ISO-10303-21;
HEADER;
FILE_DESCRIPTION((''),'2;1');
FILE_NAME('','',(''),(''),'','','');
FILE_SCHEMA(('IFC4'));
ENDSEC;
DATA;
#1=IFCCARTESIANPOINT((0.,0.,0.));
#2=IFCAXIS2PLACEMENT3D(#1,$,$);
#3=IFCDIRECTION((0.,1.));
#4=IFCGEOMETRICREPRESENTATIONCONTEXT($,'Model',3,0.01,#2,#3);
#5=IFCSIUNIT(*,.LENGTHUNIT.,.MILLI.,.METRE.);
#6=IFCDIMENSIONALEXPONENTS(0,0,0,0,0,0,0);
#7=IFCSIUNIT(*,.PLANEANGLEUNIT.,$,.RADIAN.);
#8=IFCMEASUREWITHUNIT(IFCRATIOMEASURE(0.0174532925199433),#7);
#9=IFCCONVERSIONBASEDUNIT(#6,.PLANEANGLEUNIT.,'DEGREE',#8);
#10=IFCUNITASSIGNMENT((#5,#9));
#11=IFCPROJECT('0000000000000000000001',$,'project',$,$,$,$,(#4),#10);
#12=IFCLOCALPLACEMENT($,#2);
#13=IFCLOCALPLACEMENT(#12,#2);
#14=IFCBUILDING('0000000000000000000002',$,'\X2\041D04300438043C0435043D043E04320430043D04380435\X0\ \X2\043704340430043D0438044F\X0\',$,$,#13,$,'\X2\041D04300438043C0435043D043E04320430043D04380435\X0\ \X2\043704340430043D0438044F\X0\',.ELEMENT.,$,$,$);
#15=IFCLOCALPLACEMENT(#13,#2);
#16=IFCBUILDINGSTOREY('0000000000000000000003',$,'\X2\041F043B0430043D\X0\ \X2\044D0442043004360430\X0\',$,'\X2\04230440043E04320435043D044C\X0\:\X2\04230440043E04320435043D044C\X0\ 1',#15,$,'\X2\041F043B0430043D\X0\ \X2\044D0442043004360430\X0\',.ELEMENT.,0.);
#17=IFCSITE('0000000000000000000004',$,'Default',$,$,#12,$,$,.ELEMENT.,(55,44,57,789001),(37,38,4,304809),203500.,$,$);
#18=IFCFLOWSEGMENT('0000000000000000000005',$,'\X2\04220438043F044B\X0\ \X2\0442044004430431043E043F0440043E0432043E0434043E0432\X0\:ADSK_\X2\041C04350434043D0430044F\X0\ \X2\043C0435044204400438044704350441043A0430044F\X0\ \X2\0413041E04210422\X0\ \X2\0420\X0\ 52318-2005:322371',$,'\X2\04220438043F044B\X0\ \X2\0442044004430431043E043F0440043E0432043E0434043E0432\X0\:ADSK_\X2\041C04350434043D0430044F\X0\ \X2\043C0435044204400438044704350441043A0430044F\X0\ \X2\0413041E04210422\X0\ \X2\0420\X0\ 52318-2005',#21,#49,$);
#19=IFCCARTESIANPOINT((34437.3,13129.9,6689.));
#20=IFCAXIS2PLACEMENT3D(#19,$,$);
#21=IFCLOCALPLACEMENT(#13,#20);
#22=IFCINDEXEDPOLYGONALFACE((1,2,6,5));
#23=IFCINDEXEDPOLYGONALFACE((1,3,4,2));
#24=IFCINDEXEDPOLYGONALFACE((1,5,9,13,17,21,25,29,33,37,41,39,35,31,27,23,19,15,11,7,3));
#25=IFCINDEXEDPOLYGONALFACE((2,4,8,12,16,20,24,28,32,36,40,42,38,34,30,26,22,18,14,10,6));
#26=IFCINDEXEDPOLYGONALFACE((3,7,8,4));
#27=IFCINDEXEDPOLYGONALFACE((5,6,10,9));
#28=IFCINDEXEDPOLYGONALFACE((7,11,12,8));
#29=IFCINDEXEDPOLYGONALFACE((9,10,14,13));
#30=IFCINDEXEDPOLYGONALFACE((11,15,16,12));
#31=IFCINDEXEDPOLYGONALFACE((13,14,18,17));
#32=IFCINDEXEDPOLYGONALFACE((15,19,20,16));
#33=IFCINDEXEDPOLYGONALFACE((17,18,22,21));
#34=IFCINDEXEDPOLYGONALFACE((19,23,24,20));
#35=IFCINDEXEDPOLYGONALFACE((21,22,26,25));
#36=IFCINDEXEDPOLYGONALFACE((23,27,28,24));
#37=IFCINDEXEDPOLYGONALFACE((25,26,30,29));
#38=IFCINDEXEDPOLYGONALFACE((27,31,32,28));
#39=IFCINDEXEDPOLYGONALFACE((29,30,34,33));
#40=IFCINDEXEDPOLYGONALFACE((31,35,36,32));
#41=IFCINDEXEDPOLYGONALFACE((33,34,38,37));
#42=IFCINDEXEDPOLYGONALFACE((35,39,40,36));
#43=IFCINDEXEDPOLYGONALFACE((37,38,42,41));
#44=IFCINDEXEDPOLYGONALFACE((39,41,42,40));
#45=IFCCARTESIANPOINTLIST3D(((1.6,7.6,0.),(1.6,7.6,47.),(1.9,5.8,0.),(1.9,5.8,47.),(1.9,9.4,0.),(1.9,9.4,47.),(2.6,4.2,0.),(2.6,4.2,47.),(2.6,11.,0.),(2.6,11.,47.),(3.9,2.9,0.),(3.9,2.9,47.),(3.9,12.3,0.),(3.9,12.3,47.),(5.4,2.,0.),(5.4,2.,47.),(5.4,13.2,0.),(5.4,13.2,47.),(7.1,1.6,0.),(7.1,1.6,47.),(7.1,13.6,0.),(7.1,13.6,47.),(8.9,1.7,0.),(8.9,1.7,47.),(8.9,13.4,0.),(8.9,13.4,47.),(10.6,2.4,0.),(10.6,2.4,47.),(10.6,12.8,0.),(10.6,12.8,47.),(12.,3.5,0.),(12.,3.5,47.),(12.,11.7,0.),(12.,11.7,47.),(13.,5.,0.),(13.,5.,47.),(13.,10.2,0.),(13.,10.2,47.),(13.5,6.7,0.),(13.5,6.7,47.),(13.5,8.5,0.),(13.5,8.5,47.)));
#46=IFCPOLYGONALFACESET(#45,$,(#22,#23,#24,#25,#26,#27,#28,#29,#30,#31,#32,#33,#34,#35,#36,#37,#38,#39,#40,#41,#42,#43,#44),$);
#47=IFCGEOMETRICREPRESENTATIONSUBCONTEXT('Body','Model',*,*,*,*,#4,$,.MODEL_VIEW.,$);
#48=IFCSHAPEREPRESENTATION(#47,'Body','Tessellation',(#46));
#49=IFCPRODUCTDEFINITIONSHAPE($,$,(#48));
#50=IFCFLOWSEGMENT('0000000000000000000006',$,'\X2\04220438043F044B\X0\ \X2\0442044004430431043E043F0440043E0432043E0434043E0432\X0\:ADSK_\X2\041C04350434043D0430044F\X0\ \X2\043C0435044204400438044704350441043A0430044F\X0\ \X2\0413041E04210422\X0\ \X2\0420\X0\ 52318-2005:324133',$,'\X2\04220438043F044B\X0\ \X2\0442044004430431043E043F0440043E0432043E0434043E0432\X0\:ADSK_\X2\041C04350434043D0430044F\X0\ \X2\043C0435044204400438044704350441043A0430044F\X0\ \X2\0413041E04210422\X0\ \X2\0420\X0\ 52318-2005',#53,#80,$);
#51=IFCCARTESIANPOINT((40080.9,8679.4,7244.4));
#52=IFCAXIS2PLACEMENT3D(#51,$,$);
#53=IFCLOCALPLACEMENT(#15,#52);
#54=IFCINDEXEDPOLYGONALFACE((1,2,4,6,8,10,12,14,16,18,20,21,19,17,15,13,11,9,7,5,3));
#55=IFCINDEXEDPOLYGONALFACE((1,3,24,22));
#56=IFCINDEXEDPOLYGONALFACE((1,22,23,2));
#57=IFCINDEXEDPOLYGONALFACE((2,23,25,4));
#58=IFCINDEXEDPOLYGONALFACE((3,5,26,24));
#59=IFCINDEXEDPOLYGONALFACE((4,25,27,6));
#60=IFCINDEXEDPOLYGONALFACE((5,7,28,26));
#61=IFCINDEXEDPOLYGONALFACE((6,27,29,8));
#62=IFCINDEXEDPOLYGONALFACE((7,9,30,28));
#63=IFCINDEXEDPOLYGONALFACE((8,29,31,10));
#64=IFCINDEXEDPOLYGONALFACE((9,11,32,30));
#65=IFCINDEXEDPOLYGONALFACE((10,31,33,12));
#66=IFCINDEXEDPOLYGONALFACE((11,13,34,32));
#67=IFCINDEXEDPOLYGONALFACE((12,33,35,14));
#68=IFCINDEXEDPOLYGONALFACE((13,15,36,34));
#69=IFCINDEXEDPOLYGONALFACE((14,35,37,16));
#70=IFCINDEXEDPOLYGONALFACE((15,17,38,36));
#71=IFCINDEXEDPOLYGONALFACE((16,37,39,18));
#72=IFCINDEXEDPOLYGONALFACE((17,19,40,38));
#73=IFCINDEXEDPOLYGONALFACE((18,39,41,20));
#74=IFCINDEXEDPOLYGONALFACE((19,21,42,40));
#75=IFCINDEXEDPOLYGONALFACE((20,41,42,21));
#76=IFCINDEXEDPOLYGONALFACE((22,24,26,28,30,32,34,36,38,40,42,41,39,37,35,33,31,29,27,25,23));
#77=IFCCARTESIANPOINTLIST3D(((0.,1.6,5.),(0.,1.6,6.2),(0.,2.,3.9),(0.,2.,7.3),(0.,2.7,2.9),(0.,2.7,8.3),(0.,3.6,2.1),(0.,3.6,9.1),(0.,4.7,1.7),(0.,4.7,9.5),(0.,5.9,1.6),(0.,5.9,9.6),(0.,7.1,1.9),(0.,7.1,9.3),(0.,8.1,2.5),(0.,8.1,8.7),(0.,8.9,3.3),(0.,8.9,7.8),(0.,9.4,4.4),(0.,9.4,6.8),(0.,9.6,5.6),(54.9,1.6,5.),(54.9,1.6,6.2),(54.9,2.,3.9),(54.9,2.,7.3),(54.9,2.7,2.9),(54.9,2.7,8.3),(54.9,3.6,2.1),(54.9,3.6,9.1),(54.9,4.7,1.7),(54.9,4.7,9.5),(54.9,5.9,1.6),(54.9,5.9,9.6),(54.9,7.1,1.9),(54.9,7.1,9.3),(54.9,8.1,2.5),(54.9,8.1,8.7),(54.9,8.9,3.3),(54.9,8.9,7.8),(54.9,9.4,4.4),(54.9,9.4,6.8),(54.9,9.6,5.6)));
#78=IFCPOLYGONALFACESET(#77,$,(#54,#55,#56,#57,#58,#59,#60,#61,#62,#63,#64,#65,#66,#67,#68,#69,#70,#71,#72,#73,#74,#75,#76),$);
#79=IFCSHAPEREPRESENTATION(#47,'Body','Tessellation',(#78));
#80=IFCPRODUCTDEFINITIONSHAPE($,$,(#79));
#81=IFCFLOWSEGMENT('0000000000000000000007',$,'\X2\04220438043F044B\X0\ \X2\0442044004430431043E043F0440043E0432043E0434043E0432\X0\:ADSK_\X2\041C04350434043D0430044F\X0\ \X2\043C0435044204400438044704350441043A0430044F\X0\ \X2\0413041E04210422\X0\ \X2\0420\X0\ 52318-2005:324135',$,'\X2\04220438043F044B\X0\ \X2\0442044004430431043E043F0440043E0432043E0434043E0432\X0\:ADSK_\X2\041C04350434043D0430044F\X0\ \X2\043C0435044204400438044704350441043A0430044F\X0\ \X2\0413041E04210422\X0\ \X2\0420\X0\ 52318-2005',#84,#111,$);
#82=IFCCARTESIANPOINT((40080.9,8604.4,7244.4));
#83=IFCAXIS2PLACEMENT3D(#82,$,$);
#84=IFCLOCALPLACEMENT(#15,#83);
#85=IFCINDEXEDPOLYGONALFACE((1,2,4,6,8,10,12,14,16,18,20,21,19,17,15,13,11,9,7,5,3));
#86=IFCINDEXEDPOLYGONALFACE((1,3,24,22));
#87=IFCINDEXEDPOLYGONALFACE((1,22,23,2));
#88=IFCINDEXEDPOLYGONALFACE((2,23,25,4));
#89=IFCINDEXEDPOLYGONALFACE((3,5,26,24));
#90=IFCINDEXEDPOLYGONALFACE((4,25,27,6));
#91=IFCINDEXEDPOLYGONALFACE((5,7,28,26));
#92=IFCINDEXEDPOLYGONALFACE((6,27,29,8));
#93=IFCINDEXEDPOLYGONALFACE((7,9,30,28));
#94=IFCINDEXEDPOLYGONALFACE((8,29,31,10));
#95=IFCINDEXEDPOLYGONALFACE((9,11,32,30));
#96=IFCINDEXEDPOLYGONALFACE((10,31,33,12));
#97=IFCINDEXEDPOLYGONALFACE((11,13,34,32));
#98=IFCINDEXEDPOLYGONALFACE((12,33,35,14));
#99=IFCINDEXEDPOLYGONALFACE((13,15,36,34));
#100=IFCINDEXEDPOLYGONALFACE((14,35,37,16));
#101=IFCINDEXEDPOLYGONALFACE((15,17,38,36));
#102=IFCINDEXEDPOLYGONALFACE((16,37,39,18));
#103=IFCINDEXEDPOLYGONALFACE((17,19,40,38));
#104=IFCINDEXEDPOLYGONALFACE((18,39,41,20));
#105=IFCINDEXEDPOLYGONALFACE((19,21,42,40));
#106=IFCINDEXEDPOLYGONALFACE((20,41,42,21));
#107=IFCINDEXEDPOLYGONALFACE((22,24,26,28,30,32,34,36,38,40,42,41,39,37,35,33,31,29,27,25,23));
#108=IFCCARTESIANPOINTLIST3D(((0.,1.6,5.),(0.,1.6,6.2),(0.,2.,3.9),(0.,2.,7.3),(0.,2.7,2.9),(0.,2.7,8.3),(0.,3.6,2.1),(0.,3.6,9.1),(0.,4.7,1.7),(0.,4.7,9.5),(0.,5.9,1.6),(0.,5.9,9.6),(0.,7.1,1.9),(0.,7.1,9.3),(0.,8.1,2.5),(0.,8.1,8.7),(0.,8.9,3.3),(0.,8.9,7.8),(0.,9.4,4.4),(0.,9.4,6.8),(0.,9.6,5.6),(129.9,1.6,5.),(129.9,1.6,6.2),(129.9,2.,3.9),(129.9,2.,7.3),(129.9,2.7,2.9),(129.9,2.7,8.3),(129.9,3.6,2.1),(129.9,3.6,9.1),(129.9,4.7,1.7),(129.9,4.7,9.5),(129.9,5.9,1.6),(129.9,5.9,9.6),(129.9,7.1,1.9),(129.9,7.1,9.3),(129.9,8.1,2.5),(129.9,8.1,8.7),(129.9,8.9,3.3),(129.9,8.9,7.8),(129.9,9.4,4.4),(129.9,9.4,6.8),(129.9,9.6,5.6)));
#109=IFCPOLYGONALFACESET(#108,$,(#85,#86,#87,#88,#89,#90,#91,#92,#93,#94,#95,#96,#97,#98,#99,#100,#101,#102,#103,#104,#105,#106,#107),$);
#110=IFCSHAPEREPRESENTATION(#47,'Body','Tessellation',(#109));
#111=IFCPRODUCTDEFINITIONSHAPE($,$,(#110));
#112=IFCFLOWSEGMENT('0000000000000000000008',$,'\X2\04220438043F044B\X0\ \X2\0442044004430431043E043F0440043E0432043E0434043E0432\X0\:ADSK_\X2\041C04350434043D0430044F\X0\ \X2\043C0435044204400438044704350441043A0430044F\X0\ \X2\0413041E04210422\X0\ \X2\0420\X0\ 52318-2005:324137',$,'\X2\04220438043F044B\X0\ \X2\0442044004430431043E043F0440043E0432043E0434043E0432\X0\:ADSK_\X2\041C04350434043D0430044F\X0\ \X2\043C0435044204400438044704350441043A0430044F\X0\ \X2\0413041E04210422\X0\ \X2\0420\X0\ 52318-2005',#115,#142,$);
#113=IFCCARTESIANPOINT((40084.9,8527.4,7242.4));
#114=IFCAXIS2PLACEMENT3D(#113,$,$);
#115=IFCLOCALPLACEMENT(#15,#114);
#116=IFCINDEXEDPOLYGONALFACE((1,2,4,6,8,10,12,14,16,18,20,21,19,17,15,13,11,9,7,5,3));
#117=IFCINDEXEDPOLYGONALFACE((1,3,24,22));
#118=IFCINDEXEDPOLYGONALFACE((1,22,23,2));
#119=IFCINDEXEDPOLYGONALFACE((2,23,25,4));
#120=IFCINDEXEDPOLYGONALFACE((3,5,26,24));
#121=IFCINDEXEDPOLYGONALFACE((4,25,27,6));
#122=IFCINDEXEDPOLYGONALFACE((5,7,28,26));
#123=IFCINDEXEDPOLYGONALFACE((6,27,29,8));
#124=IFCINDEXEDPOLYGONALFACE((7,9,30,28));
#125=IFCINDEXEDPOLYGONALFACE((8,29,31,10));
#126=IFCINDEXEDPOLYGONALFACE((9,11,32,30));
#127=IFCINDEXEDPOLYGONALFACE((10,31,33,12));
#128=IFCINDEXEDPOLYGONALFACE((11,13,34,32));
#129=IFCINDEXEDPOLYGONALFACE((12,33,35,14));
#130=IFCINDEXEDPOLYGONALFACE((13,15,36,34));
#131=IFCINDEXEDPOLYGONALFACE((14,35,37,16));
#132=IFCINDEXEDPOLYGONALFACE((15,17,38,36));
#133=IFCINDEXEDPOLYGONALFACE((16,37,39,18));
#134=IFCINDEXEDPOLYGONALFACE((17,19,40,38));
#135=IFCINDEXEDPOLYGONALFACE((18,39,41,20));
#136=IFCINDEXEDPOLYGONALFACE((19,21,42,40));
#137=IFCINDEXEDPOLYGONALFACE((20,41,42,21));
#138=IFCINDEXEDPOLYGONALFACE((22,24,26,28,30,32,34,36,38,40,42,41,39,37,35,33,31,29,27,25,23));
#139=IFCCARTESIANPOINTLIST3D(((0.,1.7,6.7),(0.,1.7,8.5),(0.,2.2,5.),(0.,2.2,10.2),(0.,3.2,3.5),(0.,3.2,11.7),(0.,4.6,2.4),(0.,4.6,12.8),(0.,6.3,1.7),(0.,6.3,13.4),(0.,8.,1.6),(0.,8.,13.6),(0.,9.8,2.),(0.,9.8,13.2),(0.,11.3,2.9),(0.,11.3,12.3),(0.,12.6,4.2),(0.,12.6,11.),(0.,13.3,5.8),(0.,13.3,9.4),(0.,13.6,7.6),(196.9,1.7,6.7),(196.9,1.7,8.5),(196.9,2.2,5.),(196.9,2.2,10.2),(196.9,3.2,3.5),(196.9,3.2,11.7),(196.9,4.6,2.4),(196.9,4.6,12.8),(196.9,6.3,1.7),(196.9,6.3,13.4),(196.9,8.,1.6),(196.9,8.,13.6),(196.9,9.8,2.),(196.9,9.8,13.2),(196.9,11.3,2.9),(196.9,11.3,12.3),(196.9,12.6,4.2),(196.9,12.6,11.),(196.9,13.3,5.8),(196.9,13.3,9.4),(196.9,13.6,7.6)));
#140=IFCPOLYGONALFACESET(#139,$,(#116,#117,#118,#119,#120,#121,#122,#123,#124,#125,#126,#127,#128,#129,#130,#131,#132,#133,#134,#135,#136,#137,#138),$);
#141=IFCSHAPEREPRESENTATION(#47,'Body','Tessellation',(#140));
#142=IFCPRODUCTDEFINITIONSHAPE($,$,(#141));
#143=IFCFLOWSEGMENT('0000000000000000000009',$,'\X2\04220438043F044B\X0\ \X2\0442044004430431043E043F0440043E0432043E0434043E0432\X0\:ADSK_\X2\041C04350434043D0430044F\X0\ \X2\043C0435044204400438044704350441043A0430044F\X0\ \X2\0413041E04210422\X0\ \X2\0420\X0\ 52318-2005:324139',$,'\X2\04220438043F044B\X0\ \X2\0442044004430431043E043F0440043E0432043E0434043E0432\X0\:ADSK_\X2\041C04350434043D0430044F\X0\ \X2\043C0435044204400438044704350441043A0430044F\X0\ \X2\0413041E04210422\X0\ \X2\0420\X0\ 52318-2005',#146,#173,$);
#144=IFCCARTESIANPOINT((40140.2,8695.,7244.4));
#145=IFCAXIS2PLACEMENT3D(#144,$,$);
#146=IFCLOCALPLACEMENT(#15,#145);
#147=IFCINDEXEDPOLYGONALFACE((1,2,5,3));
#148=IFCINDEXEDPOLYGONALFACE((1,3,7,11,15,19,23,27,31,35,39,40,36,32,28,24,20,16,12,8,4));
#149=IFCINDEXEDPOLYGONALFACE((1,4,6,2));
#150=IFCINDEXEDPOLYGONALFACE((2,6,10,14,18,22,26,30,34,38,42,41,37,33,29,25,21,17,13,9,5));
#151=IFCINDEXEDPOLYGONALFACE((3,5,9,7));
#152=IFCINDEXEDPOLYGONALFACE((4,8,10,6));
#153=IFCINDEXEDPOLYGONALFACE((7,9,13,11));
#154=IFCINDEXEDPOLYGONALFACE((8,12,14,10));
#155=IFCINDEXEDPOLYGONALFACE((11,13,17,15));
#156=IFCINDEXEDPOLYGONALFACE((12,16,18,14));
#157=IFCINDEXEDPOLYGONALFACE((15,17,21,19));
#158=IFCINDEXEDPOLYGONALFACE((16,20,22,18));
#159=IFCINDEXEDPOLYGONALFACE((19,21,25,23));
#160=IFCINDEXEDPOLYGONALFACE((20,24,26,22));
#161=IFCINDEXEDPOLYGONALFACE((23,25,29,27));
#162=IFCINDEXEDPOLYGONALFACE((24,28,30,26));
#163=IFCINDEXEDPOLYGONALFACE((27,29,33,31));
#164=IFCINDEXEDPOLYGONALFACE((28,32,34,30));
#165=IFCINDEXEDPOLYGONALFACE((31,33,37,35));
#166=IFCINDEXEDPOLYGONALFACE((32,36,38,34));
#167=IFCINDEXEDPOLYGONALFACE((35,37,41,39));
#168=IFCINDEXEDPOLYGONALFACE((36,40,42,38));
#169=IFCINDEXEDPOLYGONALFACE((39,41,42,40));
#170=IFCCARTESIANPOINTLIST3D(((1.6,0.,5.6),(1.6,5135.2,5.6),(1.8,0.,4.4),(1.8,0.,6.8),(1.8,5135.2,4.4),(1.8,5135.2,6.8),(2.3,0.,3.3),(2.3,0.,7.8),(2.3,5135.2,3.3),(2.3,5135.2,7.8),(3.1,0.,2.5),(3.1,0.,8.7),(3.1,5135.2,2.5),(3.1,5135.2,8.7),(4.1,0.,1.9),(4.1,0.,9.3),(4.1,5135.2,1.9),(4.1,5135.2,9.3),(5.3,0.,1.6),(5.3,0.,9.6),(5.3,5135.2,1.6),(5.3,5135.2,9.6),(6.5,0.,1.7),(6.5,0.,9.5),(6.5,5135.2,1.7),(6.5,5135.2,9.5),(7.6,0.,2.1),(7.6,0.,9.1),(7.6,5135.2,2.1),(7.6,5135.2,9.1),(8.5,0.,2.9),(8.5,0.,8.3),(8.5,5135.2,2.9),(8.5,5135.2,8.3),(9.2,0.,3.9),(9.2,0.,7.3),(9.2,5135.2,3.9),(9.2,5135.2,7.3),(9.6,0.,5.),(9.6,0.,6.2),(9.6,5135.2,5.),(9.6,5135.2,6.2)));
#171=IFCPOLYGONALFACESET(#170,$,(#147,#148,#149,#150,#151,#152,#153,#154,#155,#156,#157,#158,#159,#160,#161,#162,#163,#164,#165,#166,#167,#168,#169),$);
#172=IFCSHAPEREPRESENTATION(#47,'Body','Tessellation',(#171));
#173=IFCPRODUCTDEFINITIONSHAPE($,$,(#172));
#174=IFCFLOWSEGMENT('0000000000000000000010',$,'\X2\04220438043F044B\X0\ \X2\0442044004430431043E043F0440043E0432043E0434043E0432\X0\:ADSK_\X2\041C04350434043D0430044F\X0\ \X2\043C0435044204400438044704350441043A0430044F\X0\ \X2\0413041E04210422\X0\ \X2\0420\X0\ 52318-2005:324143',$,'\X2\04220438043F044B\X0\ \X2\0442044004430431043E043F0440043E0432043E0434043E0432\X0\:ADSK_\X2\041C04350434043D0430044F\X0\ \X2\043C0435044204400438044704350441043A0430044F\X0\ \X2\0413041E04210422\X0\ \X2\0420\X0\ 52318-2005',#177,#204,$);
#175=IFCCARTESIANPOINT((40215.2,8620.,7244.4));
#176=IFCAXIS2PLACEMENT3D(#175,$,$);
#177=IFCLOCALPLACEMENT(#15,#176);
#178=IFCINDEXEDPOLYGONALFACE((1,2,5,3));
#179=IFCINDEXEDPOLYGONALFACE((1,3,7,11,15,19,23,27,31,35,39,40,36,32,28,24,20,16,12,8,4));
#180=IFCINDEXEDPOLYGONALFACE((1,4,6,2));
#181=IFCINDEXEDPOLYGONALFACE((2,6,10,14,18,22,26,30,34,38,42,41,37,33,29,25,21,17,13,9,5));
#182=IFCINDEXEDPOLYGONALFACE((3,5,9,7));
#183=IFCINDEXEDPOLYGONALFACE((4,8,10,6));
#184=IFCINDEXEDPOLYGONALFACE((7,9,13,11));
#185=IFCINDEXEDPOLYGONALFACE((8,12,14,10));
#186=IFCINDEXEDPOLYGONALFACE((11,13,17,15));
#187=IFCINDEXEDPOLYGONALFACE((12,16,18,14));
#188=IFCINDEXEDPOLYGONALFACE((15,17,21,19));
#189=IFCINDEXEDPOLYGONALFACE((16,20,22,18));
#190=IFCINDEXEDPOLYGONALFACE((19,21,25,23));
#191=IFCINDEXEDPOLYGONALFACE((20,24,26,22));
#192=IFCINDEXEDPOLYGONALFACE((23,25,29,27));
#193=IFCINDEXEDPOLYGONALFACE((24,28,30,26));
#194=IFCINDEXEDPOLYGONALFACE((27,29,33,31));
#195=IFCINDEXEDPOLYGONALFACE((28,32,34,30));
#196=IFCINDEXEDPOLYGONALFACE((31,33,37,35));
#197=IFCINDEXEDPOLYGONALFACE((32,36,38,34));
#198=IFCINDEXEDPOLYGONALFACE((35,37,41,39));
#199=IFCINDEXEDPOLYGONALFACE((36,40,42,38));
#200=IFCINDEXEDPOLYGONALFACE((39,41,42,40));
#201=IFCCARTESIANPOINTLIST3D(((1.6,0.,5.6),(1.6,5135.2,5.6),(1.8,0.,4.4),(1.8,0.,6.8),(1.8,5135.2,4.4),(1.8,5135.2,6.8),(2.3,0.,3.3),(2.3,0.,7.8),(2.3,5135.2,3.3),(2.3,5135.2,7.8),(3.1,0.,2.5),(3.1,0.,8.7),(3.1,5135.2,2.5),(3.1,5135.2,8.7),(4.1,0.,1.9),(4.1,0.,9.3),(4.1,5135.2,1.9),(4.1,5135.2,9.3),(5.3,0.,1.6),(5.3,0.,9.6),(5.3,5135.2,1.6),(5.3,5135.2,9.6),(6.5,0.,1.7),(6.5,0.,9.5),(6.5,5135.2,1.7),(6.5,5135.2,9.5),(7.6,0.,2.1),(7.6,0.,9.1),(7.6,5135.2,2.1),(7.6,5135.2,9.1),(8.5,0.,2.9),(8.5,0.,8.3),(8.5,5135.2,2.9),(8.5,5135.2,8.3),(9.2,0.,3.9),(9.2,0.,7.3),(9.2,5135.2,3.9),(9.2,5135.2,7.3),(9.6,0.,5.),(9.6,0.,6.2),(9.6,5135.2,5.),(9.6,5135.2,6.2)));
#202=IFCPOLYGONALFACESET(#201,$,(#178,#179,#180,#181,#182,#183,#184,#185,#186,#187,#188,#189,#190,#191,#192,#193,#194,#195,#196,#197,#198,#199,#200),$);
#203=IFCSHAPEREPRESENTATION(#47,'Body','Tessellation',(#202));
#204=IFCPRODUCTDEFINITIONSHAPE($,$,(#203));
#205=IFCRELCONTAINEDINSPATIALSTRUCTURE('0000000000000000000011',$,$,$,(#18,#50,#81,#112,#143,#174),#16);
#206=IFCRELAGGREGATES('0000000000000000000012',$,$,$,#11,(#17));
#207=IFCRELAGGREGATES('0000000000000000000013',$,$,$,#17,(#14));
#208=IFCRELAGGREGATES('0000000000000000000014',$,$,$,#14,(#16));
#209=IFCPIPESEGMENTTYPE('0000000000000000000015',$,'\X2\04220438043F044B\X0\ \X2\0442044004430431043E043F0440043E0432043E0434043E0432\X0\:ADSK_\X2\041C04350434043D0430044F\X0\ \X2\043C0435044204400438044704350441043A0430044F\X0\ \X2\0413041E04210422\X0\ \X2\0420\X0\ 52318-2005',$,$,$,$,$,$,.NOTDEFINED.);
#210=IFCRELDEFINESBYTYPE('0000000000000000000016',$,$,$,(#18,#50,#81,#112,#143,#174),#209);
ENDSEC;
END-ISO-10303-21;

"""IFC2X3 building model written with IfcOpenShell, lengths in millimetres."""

from ifc_helpers import new_model, entity, si_unit, converted_unit, direction, frame, frame_2d, origin, place, context, subcontext, project, spatial, circle, extrude, type_object, element, save


model = new_model("IFC2X3")

# Units and contexts
model_context = context("Model", 3, precision=0.01, world=origin(), true_north=direction((0.0, 1.0)))
body_context = subcontext(model_context, "Body", "Model", "MODEL_VIEW")
ifc_project = project(units=[si_unit("LENGTHUNIT", "METRE", prefix="MILLI"), converted_unit("PLANEANGLEUNIT", "DEGREE", entity("IfcRatioMeasure", 0.0174532925199433), si_unit("PLANEANGLEUNIT", "RADIAN"), dimensions=[0, 0, 0, 0, 0, 0, 0])], contexts=[model_context])

# Site, building, storey
site_placement = place(None, frame((0.0, 0.0, 0.0)))
site = spatial("IfcSite", under=ifc_project, at=site_placement, Name="Default", CompositionType="ELEMENT", RefLatitude=(55, 44, 57, 789001), RefLongitude=(37, 38, 4, 304809), RefElevation=203500.0)
building_placement = place(site_placement, origin())
building = spatial("IfcBuilding", under=site, at=building_placement, Name="Наименование здания", LongName="Наименование здания", CompositionType="ELEMENT")
storey_placement = place(building_placement, origin())
storey = spatial("IfcBuildingStorey", under=building, at=storey_placement, Name="План этажа", ObjectType="Уровень:Уровень 1", LongName="План этажа", CompositionType="ELEMENT", Elevation=0.0)

# Flow segments
pipe_segment_type = type_object("IfcPipeSegmentType", Name="Типы трубопроводов:ADSK_Медная метрическая ГОСТ Р 52318-2005", PredefinedType="NOTDEFINED")
flow_segment_1_placement = place(building_placement, frame((34437.3, 13129.9, 6689.0)))
element("IfcFlowSegment", 1, at=flow_segment_1_placement, inside=storey, type_object=pipe_segment_type, Name="Типы трубопроводов:ADSK_Медная метрическая ГОСТ Р 52318-2005:322371", ObjectType="Типы трубопроводов:ADSK_Медная метрическая ГОСТ Р 52318-2005", context=body_context, shape_type="SweptSolid", body=[
    extrude(circle(Radius=6.0, at=frame_2d((0.0, 0.0), x_axis=(1.0, 0.0))), frame((7.6, 7.6, 0.0), z_axis=(0.0, 0.0, 1.0), x_axis=(-1.0, 0.0, 0.0)), (0.0, 0.0, 1.0), 47.0),
])
flow_segment_2_placement = place(storey_placement, frame((40080.9, 8679.4, 7244.4)))
element("IfcFlowSegment", 2, at=flow_segment_2_placement, inside=storey, type_object=pipe_segment_type, Name="Типы трубопроводов:ADSK_Медная метрическая ГОСТ Р 52318-2005:324133", ObjectType="Типы трубопроводов:ADSK_Медная метрическая ГОСТ Р 52318-2005", context=body_context, shape_type="SweptSolid", body=[
    extrude(circle(Radius=4.0, at=frame_2d((0.0, 0.0), x_axis=(1.0, 0.0))), frame((0.0, 5.6, 5.6), z_axis=(1.0, 0.0, 0.0), x_axis=(0.0, 1.0, 0.0)), (0.0, 0.0, 1.0), 54.9),
])
flow_segment_3_placement = place(storey_placement, frame((40080.9, 8604.4, 7244.4)))
element("IfcFlowSegment", 3, at=flow_segment_3_placement, inside=storey, type_object=pipe_segment_type, Name="Типы трубопроводов:ADSK_Медная метрическая ГОСТ Р 52318-2005:324135", ObjectType="Типы трубопроводов:ADSK_Медная метрическая ГОСТ Р 52318-2005", context=body_context, shape_type="SweptSolid", body=[
    extrude(circle(Radius=4.0, at=frame_2d((0.0, 0.0), x_axis=(1.0, 0.0))), frame((0.0, 5.6, 5.6), z_axis=(1.0, 0.0, 0.0), x_axis=(0.0, 1.0, 0.0)), (0.0, 0.0, 1.0), 129.9),
])
flow_segment_4_placement = place(storey_placement, frame((40084.9, 8527.4, 7242.4)))
element("IfcFlowSegment", 4, at=flow_segment_4_placement, inside=storey, type_object=pipe_segment_type, Name="Типы трубопроводов:ADSK_Медная метрическая ГОСТ Р 52318-2005:324137", ObjectType="Типы трубопроводов:ADSK_Медная метрическая ГОСТ Р 52318-2005", context=body_context, shape_type="SweptSolid", body=[
    extrude(circle(Radius=6.0, at=frame_2d((0.0, 0.0), x_axis=(1.0, 0.0))), frame((0.0, 7.6, 7.6), z_axis=(1.0, 0.0, 0.0), x_axis=(0.0, 1.0, 0.0)), (0.0, 0.0, 1.0), 196.9),
])
flow_segment_5_placement = place(storey_placement, frame((40140.2, 8695.0, 7244.4)))
element("IfcFlowSegment", 5, at=flow_segment_5_placement, inside=storey, type_object=pipe_segment_type, Name="Типы трубопроводов:ADSK_Медная метрическая ГОСТ Р 52318-2005:324139", ObjectType="Типы трубопроводов:ADSK_Медная метрическая ГОСТ Р 52318-2005", context=body_context, shape_type="SweptSolid", body=[
    extrude(circle(Radius=4.0, at=frame_2d((0.0, 0.0), x_axis=(1.0, 0.0))), frame((5.6, 0.0, 5.6), z_axis=(0.0, 1.0, 0.0), x_axis=(-1.0, 0.0, 0.0)), (0.0, 0.0, 1.0), 5135.2),
])
flow_segment_6_placement = place(storey_placement, frame((40215.2, 8620.0, 7244.4)))
element("IfcFlowSegment", 6, at=flow_segment_6_placement, inside=storey, type_object=pipe_segment_type, Name="Типы трубопроводов:ADSK_Медная метрическая ГОСТ Р 52318-2005:324143", ObjectType="Типы трубопроводов:ADSK_Медная метрическая ГОСТ Р 52318-2005", context=body_context, shape_type="SweptSolid", body=[
    extrude(circle(Radius=4.0, at=frame_2d((0.0, 0.0), x_axis=(1.0, 0.0))), frame((5.6, 0.0, 5.6), z_axis=(0.0, 1.0, 0.0), x_axis=(-1.0, 0.0, 0.0)), (0.0, 0.0, 1.0), 5135.2),
])

save(model, "model.ifc")
